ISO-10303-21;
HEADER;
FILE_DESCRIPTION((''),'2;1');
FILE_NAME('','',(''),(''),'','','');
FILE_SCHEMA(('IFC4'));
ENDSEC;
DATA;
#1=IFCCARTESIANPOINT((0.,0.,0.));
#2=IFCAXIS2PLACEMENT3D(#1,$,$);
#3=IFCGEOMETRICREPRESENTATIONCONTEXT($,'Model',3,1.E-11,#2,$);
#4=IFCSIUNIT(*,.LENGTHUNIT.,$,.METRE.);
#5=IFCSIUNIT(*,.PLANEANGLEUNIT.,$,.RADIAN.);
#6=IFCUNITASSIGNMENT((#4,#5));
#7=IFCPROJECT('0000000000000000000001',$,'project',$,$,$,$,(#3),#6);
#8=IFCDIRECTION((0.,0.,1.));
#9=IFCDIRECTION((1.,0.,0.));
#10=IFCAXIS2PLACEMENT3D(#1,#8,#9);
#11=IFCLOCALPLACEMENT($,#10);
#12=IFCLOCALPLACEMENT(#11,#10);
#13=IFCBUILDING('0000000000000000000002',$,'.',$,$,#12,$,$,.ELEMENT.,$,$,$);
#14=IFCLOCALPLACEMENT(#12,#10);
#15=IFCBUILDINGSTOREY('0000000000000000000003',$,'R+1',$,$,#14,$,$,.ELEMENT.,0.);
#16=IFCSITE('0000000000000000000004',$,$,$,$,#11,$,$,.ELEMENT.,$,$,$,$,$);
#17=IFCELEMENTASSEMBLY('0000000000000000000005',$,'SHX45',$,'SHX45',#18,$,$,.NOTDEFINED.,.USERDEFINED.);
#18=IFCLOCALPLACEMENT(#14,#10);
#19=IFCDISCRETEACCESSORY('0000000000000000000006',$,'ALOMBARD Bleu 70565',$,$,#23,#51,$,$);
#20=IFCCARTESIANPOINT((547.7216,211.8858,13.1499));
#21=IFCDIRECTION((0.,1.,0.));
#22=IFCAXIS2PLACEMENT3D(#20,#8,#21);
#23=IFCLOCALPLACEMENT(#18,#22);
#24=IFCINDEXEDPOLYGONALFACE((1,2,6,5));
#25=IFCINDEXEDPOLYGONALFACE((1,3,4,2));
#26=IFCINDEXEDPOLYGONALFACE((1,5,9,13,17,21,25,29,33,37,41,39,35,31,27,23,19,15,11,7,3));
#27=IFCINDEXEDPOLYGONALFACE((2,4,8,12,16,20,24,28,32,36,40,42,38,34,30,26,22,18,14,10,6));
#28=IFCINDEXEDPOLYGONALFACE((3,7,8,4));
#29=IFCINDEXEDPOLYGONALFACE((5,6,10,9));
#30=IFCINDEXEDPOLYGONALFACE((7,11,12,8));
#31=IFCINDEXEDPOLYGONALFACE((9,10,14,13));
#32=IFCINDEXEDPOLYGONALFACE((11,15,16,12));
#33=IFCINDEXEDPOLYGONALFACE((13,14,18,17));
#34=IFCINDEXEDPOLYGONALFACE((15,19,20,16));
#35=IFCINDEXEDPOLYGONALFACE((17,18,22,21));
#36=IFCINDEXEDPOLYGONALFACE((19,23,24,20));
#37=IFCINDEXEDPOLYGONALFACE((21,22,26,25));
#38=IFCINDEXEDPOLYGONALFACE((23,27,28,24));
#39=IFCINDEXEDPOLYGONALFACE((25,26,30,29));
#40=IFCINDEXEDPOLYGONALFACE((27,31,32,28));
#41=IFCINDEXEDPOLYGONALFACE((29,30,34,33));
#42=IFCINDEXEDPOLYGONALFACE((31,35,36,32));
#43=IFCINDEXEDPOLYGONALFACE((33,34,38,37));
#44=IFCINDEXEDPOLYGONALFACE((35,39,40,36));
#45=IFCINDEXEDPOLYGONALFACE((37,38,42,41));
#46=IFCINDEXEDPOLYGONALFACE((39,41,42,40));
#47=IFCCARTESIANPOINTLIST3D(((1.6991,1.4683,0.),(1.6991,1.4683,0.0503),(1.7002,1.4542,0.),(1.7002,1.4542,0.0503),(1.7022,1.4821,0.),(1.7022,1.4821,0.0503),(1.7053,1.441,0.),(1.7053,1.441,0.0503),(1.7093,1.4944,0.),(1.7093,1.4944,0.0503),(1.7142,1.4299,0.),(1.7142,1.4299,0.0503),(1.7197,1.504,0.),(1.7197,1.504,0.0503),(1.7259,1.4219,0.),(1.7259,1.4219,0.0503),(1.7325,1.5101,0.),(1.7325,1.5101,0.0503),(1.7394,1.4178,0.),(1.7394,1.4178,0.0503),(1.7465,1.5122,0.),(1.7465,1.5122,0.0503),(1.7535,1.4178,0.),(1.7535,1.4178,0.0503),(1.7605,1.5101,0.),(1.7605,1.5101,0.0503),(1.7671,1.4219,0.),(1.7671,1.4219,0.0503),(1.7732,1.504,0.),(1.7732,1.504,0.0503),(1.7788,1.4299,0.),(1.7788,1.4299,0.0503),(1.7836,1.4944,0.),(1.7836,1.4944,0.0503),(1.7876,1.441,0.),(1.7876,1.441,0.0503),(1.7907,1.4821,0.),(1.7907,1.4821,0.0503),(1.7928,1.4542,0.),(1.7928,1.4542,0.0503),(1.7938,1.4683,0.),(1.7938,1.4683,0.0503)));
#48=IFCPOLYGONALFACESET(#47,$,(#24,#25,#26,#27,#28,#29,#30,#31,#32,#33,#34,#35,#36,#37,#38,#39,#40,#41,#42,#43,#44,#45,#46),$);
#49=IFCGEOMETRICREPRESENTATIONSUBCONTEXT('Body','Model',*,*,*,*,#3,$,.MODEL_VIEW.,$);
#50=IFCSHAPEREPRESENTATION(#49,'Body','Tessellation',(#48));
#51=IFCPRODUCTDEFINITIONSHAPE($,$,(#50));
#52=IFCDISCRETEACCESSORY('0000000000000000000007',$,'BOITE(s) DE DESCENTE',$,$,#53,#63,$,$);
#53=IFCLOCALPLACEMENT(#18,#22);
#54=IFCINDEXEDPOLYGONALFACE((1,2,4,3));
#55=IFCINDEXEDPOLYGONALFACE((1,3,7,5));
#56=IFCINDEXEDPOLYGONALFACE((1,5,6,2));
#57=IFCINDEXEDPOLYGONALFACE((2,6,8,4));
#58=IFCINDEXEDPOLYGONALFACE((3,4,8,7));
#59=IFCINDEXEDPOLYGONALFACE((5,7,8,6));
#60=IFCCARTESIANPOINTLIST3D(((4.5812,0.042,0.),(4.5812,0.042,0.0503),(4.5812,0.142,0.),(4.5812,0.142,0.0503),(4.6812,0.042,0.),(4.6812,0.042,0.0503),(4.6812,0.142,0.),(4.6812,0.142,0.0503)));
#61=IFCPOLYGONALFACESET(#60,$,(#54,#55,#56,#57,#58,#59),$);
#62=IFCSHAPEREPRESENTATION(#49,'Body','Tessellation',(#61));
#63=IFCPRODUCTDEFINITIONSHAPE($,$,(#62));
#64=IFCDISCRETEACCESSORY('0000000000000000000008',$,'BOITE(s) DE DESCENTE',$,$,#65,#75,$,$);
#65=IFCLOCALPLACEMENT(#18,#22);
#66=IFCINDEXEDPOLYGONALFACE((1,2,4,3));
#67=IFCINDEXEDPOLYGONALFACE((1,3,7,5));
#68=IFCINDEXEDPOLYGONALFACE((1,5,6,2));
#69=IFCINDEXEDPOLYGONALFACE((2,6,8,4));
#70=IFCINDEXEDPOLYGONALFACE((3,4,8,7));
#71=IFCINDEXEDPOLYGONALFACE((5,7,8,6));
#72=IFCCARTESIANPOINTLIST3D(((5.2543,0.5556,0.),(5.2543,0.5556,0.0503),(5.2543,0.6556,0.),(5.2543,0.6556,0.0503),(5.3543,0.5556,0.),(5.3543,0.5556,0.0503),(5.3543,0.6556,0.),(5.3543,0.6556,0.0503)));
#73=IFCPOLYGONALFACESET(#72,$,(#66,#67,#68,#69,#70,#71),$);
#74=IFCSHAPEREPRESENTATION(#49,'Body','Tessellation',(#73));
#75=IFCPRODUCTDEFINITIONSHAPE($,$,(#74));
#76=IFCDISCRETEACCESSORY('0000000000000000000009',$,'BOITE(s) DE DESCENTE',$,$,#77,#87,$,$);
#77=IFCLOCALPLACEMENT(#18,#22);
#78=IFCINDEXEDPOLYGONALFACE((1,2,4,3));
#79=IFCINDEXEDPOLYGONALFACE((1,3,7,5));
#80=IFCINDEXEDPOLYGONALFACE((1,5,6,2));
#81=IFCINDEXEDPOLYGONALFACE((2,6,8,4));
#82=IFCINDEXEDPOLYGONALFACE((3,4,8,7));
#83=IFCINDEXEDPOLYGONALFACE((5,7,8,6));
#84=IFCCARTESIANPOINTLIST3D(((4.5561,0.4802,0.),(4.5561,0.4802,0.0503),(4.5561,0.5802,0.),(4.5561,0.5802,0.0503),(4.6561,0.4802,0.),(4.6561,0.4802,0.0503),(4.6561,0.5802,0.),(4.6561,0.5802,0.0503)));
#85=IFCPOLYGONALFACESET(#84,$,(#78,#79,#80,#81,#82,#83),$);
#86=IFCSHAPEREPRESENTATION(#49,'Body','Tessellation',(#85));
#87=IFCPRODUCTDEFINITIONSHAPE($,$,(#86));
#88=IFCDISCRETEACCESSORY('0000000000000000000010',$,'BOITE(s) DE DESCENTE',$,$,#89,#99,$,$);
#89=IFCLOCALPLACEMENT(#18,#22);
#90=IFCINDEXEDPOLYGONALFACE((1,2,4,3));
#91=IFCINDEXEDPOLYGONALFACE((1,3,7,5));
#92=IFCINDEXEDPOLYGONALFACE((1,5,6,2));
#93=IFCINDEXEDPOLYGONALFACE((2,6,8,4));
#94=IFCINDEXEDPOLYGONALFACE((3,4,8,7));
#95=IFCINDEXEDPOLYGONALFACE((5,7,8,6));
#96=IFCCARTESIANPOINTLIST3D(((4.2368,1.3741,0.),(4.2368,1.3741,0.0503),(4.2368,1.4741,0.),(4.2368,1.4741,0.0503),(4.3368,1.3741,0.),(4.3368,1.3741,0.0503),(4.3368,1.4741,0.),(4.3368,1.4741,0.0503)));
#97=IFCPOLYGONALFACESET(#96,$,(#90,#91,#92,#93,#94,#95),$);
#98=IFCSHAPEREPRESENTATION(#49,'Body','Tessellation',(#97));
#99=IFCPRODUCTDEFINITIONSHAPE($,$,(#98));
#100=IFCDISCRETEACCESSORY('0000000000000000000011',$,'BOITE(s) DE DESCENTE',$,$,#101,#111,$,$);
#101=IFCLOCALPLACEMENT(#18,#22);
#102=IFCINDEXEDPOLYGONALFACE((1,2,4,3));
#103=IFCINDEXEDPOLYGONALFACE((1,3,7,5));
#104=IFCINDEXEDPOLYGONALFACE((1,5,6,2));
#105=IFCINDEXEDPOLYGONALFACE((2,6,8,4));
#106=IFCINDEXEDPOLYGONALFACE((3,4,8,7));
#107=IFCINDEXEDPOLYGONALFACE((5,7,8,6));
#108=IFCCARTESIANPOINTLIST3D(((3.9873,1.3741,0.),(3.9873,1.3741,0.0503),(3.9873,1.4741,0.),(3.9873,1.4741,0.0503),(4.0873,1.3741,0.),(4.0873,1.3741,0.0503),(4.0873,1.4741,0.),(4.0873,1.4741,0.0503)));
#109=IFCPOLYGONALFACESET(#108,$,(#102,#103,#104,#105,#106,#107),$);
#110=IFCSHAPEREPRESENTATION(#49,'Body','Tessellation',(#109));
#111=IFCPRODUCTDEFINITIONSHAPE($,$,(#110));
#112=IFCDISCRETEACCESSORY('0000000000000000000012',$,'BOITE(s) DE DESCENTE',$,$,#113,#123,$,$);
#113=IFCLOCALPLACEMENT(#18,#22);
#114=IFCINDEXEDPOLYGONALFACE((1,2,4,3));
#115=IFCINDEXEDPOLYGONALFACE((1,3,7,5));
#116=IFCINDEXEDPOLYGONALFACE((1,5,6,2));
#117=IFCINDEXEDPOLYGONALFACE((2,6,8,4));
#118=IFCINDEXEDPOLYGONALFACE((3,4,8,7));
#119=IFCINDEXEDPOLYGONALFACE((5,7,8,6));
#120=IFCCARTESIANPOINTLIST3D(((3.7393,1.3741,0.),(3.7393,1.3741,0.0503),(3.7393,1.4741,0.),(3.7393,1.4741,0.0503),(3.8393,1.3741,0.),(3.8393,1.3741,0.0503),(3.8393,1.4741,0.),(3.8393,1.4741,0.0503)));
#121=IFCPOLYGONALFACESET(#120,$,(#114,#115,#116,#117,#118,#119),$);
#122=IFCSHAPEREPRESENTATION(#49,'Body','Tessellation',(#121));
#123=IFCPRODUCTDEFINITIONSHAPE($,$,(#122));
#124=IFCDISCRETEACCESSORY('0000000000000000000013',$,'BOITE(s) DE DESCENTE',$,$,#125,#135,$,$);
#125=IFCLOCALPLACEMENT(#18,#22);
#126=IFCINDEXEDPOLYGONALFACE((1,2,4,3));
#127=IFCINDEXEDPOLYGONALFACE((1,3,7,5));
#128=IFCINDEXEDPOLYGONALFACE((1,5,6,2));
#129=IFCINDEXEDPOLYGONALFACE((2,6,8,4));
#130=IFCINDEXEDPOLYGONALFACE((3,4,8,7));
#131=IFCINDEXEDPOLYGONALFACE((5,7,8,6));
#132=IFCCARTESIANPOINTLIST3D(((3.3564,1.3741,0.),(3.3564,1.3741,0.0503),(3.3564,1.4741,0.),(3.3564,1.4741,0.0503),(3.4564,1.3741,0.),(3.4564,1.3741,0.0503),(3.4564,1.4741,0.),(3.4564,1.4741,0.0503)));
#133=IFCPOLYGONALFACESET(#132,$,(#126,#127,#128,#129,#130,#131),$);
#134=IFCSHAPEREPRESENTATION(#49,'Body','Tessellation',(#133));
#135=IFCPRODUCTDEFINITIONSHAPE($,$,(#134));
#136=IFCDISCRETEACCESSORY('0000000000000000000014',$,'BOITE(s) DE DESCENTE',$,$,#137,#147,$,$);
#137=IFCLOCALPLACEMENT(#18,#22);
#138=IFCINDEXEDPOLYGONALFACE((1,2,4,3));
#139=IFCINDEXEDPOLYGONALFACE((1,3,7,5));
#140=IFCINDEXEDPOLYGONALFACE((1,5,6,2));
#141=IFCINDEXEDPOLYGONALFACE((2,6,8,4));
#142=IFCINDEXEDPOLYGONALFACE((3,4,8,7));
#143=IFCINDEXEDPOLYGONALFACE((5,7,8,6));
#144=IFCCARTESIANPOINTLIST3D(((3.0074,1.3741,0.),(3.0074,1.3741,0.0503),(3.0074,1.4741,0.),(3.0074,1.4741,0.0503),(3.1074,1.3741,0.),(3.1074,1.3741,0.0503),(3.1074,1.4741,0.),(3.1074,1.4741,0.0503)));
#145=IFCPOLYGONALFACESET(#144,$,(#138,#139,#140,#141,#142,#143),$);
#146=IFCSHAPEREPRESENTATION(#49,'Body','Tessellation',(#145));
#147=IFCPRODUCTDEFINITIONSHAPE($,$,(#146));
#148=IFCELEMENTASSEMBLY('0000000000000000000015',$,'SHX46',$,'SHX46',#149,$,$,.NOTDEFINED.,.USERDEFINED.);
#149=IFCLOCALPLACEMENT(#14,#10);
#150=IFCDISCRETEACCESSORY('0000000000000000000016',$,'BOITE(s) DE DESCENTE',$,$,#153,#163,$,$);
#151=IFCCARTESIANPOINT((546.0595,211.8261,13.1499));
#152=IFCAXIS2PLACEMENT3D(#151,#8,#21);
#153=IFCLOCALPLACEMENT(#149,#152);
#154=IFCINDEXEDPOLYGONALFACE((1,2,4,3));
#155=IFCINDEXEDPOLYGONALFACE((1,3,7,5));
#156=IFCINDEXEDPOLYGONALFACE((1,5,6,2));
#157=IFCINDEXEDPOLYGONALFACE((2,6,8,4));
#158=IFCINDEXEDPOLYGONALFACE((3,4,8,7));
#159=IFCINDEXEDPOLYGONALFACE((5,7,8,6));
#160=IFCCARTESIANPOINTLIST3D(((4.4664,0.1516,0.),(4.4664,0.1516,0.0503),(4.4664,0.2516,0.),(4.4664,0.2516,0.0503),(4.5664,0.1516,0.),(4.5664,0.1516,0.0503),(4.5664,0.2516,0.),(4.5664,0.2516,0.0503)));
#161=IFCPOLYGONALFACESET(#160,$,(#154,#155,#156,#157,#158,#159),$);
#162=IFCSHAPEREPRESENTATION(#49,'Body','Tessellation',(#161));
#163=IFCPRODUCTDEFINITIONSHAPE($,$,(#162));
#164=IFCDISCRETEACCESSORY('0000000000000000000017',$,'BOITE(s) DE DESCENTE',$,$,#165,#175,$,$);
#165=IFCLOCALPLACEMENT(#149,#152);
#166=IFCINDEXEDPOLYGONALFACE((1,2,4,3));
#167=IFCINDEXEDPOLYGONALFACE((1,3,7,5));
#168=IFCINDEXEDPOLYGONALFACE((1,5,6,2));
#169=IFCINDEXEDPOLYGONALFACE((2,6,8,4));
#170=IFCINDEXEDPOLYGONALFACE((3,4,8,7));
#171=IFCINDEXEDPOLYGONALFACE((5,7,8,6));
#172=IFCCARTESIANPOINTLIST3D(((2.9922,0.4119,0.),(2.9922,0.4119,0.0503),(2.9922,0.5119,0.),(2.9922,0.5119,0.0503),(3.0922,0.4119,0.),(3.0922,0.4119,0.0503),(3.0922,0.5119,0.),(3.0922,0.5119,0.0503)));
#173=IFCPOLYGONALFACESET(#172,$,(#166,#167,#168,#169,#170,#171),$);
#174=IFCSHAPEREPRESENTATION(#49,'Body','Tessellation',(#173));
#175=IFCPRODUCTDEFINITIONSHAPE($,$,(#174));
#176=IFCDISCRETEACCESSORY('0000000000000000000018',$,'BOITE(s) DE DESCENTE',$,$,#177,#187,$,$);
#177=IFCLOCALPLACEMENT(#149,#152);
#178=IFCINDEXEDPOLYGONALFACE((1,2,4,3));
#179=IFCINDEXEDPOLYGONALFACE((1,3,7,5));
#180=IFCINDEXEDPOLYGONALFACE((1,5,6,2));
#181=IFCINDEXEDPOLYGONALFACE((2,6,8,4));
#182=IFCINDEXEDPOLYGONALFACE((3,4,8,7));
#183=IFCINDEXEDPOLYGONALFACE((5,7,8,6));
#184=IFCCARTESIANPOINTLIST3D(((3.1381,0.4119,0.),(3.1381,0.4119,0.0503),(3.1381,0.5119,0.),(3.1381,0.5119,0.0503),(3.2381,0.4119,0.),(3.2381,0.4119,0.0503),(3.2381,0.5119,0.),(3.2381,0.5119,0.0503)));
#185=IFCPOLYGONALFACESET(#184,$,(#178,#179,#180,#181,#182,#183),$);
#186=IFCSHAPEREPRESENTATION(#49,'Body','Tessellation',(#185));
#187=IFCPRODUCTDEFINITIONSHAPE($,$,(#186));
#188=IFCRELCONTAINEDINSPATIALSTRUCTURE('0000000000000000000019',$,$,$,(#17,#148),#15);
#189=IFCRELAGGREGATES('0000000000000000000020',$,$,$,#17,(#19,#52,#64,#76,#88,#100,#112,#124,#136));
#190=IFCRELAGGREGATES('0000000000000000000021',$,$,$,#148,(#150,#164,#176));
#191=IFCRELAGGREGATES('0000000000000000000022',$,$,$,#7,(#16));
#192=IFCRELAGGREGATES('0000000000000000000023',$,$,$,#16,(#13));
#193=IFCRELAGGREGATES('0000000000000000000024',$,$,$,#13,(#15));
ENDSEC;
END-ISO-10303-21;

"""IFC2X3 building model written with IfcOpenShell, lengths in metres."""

from ifc_helpers import new_model, si_unit, frame, frame_2d, origin, origin_with_axes, place, context, subcontext, project, spatial, polyline, circle, outline, extrude, element, aggregate, save


model = new_model("IFC2X3")

# Units and contexts
model_context = context("Model", 3, precision=1e-11, world=origin())
body_context = subcontext(model_context, "Body", "Model", "MODEL_VIEW")
ifc_project = project(units=[si_unit("LENGTHUNIT", "METRE"), si_unit("PLANEANGLEUNIT", "RADIAN")], contexts=[model_context])

# Site, building, storey
site_placement = place(None, origin_with_axes())
site = spatial("IfcSite", under=ifc_project, at=site_placement, CompositionType="ELEMENT")
building_placement = place(site_placement, origin_with_axes())
building = spatial("IfcBuilding", under=site, at=building_placement, Name=".", CompositionType="ELEMENT")
storey_placement = place(building_placement, origin_with_axes())
storey = spatial("IfcBuildingStorey", under=building, at=storey_placement, Name="R+1", CompositionType="ELEMENT", Elevation=0.0)

# Element assembly, discrete accessories
assembly_1_placement = place(storey_placement, origin_with_axes())
assembly_1 = element("IfcElementAssembly", 1, at=assembly_1_placement, inside=storey, Name="SHX45", ObjectType="SHX45", AssemblyPlace="NOTDEFINED", PredefinedType="USERDEFINED")
discrete_accessory_1_placement = place(assembly_1_placement, frame((547.7216, 211.8858, 13.1499), z_axis=(0.0, 0.0, 1.0), x_axis=(0.0, 1.0, 0.0)))
discrete_accessory_1 = element("IfcDiscreteAccessory", 2, at=discrete_accessory_1_placement, Name="ALOMBARD Bleu 70565", context=body_context, shape_type="SweptSolid", body=[
    extrude(circle(Radius=0.0475, at=frame_2d((1.4647, -1.7465), x_axis=(1.0, 0.0))), frame((0.0, 0.0, 0.0), z_axis=(0.0, 0.0, 1.0), x_axis=(0.0, 1.0, 0.0)), (0.0, 0.0, 1.0), 0.0503),
])
discrete_accessory_2_placement = place(assembly_1_placement, frame((547.7216, 211.8858, 13.1499), z_axis=(0.0, 0.0, 1.0), x_axis=(0.0, 1.0, 0.0)))
discrete_accessory_2 = element("IfcDiscreteAccessory", 3, at=discrete_accessory_2_placement, Name="BOITE(s) DE DESCENTE", context=body_context, shape_type="SweptSolid", body=[
    extrude(outline(polyline([(0.042, -4.5812), (0.042, -4.6812), (0.142, -4.6812), (0.142, -4.5812), (0.042, -4.5812)])), frame((0.0, 0.0, 0.0), z_axis=(0.0, 0.0, 1.0), x_axis=(0.0, 1.0, 0.0)), (0.0, 0.0, 1.0), 0.0503),
])
discrete_accessory_3_placement = place(assembly_1_placement, frame((547.7216, 211.8858, 13.1499), z_axis=(0.0, 0.0, 1.0), x_axis=(0.0, 1.0, 0.0)))
discrete_accessory_3 = element("IfcDiscreteAccessory", 4, at=discrete_accessory_3_placement, Name="BOITE(s) DE DESCENTE", context=body_context, shape_type="SweptSolid", body=[
    extrude(outline(polyline([(0.5556, -5.2543), (0.5556, -5.3543), (0.6556, -5.3543), (0.6556, -5.2543), (0.5556, -5.2543)])), frame((0.0, 0.0, 0.0), z_axis=(0.0, 0.0, 1.0), x_axis=(0.0, 1.0, 0.0)), (0.0, 0.0, 1.0), 0.0503),
])
discrete_accessory_4_placement = place(assembly_1_placement, frame((547.7216, 211.8858, 13.1499), z_axis=(0.0, 0.0, 1.0), x_axis=(0.0, 1.0, 0.0)))
discrete_accessory_4 = element("IfcDiscreteAccessory", 5, at=discrete_accessory_4_placement, Name="BOITE(s) DE DESCENTE", context=body_context, shape_type="SweptSolid", body=[
    extrude(outline(polyline([(0.4802, -4.5561), (0.4802, -4.6561), (0.5802, -4.6561), (0.5802, -4.5561), (0.4802, -4.5561)])), frame((0.0, 0.0, 0.0), z_axis=(0.0, 0.0, 1.0), x_axis=(0.0, 1.0, 0.0)), (0.0, 0.0, 1.0), 0.0503),
])
discrete_accessory_5_placement = place(assembly_1_placement, frame((547.7216, 211.8858, 13.1499), z_axis=(0.0, 0.0, 1.0), x_axis=(0.0, 1.0, 0.0)))
discrete_accessory_5 = element("IfcDiscreteAccessory", 6, at=discrete_accessory_5_placement, Name="BOITE(s) DE DESCENTE", context=body_context, shape_type="SweptSolid", body=[
    extrude(outline(polyline([(1.3741, -4.2368), (1.3741, -4.3368), (1.4741, -4.3368), (1.4741, -4.2368), (1.3741, -4.2368)])), frame((0.0, 0.0, 0.0), z_axis=(0.0, 0.0, 1.0), x_axis=(0.0, 1.0, 0.0)), (0.0, 0.0, 1.0), 0.0503),
])
discrete_accessory_6_placement = place(assembly_1_placement, frame((547.7216, 211.8858, 13.1499), z_axis=(0.0, 0.0, 1.0), x_axis=(0.0, 1.0, 0.0)))
discrete_accessory_6 = element("IfcDiscreteAccessory", 7, at=discrete_accessory_6_placement, Name="BOITE(s) DE DESCENTE", context=body_context, shape_type="SweptSolid", body=[
    extrude(outline(polyline([(1.3741, -3.9873), (1.3741, -4.0873), (1.4741, -4.0873), (1.4741, -3.9873), (1.3741, -3.9873)])), frame((0.0, 0.0, 0.0), z_axis=(0.0, 0.0, 1.0), x_axis=(0.0, 1.0, 0.0)), (0.0, 0.0, 1.0), 0.0503),
])
discrete_accessory_7_placement = place(assembly_1_placement, frame((547.7216, 211.8858, 13.1499), z_axis=(0.0, 0.0, 1.0), x_axis=(0.0, 1.0, 0.0)))
discrete_accessory_7 = element("IfcDiscreteAccessory", 8, at=discrete_accessory_7_placement, Name="BOITE(s) DE DESCENTE", context=body_context, shape_type="SweptSolid", body=[
    extrude(outline(polyline([(1.3741, -3.7393), (1.3741, -3.8393), (1.4741, -3.8393), (1.4741, -3.7393), (1.3741, -3.7393)])), frame((0.0, 0.0, 0.0), z_axis=(0.0, 0.0, 1.0), x_axis=(0.0, 1.0, 0.0)), (0.0, 0.0, 1.0), 0.0503),
])
discrete_accessory_8_placement = place(assembly_1_placement, frame((547.7216, 211.8858, 13.1499), z_axis=(0.0, 0.0, 1.0), x_axis=(0.0, 1.0, 0.0)))
discrete_accessory_8 = element("IfcDiscreteAccessory", 9, at=discrete_accessory_8_placement, Name="BOITE(s) DE DESCENTE", context=body_context, shape_type="SweptSolid", body=[
    extrude(outline(polyline([(1.3741, -3.3564), (1.3741, -3.4564), (1.4741, -3.4564), (1.4741, -3.3564), (1.3741, -3.3564)])), frame((0.0, 0.0, 0.0), z_axis=(0.0, 0.0, 1.0), x_axis=(0.0, 1.0, 0.0)), (0.0, 0.0, 1.0), 0.0503),
])
discrete_accessory_9_placement = place(assembly_1_placement, frame((547.7216, 211.8858, 13.1499), z_axis=(0.0, 0.0, 1.0), x_axis=(0.0, 1.0, 0.0)))
discrete_accessory_9 = element("IfcDiscreteAccessory", 10, at=discrete_accessory_9_placement, Name="BOITE(s) DE DESCENTE", context=body_context, shape_type="SweptSolid", body=[
    extrude(outline(polyline([(1.3741, -3.0074), (1.3741, -3.1074), (1.4741, -3.1074), (1.4741, -3.0074), (1.3741, -3.0074)])), frame((0.0, 0.0, 0.0), z_axis=(0.0, 0.0, 1.0), x_axis=(0.0, 1.0, 0.0)), (0.0, 0.0, 1.0), 0.0503),
])
aggregate(assembly_1, [discrete_accessory_1, discrete_accessory_2, discrete_accessory_3, discrete_accessory_4, discrete_accessory_5, discrete_accessory_6, discrete_accessory_7, discrete_accessory_8, discrete_accessory_9])

# Element assembly, discrete accessories
assembly_2_placement = place(storey_placement, origin_with_axes())
assembly_2 = element("IfcElementAssembly", 11, at=assembly_2_placement, inside=storey, Name="SHX46", ObjectType="SHX46", AssemblyPlace="NOTDEFINED", PredefinedType="USERDEFINED")
discrete_accessory_10_placement = place(assembly_2_placement, frame((546.0595, 211.8261, 13.1499), z_axis=(0.0, 0.0, 1.0), x_axis=(0.0, 1.0, 0.0)))
discrete_accessory_10 = element("IfcDiscreteAccessory", 12, at=discrete_accessory_10_placement, Name="BOITE(s) DE DESCENTE", context=body_context, shape_type="SweptSolid", body=[
    extrude(outline(polyline([(0.1516, -4.4664), (0.1516, -4.5664), (0.2516, -4.5664), (0.2516, -4.4664), (0.1516, -4.4664)])), frame((0.0, 0.0, 0.0), z_axis=(0.0, 0.0, 1.0), x_axis=(0.0, 1.0, 0.0)), (0.0, 0.0, 1.0), 0.0503),
])
discrete_accessory_11_placement = place(assembly_2_placement, frame((546.0595, 211.8261, 13.1499), z_axis=(0.0, 0.0, 1.0), x_axis=(0.0, 1.0, 0.0)))
discrete_accessory_11 = element("IfcDiscreteAccessory", 13, at=discrete_accessory_11_placement, Name="BOITE(s) DE DESCENTE", context=body_context, shape_type="SweptSolid", body=[
    extrude(outline(polyline([(0.4119, -2.9922), (0.4119, -3.0922), (0.5119, -3.0922), (0.5119, -2.9922), (0.4119, -2.9922)])), frame((0.0, 0.0, 0.0), z_axis=(0.0, 0.0, 1.0), x_axis=(0.0, 1.0, 0.0)), (0.0, 0.0, 1.0), 0.0503),
])
discrete_accessory_12_placement = place(assembly_2_placement, frame((546.0595, 211.8261, 13.1499), z_axis=(0.0, 0.0, 1.0), x_axis=(0.0, 1.0, 0.0)))
discrete_accessory_12 = element("IfcDiscreteAccessory", 14, at=discrete_accessory_12_placement, Name="BOITE(s) DE DESCENTE", context=body_context, shape_type="SweptSolid", body=[
    extrude(outline(polyline([(0.4119, -3.1381), (0.4119, -3.2381), (0.5119, -3.2381), (0.5119, -3.1381), (0.4119, -3.1381)])), frame((0.0, 0.0, 0.0), z_axis=(0.0, 0.0, 1.0), x_axis=(0.0, 1.0, 0.0)), (0.0, 0.0, 1.0), 0.0503),
])
aggregate(assembly_2, [discrete_accessory_10, discrete_accessory_11, discrete_accessory_12])

save(model, "model.ifc")
